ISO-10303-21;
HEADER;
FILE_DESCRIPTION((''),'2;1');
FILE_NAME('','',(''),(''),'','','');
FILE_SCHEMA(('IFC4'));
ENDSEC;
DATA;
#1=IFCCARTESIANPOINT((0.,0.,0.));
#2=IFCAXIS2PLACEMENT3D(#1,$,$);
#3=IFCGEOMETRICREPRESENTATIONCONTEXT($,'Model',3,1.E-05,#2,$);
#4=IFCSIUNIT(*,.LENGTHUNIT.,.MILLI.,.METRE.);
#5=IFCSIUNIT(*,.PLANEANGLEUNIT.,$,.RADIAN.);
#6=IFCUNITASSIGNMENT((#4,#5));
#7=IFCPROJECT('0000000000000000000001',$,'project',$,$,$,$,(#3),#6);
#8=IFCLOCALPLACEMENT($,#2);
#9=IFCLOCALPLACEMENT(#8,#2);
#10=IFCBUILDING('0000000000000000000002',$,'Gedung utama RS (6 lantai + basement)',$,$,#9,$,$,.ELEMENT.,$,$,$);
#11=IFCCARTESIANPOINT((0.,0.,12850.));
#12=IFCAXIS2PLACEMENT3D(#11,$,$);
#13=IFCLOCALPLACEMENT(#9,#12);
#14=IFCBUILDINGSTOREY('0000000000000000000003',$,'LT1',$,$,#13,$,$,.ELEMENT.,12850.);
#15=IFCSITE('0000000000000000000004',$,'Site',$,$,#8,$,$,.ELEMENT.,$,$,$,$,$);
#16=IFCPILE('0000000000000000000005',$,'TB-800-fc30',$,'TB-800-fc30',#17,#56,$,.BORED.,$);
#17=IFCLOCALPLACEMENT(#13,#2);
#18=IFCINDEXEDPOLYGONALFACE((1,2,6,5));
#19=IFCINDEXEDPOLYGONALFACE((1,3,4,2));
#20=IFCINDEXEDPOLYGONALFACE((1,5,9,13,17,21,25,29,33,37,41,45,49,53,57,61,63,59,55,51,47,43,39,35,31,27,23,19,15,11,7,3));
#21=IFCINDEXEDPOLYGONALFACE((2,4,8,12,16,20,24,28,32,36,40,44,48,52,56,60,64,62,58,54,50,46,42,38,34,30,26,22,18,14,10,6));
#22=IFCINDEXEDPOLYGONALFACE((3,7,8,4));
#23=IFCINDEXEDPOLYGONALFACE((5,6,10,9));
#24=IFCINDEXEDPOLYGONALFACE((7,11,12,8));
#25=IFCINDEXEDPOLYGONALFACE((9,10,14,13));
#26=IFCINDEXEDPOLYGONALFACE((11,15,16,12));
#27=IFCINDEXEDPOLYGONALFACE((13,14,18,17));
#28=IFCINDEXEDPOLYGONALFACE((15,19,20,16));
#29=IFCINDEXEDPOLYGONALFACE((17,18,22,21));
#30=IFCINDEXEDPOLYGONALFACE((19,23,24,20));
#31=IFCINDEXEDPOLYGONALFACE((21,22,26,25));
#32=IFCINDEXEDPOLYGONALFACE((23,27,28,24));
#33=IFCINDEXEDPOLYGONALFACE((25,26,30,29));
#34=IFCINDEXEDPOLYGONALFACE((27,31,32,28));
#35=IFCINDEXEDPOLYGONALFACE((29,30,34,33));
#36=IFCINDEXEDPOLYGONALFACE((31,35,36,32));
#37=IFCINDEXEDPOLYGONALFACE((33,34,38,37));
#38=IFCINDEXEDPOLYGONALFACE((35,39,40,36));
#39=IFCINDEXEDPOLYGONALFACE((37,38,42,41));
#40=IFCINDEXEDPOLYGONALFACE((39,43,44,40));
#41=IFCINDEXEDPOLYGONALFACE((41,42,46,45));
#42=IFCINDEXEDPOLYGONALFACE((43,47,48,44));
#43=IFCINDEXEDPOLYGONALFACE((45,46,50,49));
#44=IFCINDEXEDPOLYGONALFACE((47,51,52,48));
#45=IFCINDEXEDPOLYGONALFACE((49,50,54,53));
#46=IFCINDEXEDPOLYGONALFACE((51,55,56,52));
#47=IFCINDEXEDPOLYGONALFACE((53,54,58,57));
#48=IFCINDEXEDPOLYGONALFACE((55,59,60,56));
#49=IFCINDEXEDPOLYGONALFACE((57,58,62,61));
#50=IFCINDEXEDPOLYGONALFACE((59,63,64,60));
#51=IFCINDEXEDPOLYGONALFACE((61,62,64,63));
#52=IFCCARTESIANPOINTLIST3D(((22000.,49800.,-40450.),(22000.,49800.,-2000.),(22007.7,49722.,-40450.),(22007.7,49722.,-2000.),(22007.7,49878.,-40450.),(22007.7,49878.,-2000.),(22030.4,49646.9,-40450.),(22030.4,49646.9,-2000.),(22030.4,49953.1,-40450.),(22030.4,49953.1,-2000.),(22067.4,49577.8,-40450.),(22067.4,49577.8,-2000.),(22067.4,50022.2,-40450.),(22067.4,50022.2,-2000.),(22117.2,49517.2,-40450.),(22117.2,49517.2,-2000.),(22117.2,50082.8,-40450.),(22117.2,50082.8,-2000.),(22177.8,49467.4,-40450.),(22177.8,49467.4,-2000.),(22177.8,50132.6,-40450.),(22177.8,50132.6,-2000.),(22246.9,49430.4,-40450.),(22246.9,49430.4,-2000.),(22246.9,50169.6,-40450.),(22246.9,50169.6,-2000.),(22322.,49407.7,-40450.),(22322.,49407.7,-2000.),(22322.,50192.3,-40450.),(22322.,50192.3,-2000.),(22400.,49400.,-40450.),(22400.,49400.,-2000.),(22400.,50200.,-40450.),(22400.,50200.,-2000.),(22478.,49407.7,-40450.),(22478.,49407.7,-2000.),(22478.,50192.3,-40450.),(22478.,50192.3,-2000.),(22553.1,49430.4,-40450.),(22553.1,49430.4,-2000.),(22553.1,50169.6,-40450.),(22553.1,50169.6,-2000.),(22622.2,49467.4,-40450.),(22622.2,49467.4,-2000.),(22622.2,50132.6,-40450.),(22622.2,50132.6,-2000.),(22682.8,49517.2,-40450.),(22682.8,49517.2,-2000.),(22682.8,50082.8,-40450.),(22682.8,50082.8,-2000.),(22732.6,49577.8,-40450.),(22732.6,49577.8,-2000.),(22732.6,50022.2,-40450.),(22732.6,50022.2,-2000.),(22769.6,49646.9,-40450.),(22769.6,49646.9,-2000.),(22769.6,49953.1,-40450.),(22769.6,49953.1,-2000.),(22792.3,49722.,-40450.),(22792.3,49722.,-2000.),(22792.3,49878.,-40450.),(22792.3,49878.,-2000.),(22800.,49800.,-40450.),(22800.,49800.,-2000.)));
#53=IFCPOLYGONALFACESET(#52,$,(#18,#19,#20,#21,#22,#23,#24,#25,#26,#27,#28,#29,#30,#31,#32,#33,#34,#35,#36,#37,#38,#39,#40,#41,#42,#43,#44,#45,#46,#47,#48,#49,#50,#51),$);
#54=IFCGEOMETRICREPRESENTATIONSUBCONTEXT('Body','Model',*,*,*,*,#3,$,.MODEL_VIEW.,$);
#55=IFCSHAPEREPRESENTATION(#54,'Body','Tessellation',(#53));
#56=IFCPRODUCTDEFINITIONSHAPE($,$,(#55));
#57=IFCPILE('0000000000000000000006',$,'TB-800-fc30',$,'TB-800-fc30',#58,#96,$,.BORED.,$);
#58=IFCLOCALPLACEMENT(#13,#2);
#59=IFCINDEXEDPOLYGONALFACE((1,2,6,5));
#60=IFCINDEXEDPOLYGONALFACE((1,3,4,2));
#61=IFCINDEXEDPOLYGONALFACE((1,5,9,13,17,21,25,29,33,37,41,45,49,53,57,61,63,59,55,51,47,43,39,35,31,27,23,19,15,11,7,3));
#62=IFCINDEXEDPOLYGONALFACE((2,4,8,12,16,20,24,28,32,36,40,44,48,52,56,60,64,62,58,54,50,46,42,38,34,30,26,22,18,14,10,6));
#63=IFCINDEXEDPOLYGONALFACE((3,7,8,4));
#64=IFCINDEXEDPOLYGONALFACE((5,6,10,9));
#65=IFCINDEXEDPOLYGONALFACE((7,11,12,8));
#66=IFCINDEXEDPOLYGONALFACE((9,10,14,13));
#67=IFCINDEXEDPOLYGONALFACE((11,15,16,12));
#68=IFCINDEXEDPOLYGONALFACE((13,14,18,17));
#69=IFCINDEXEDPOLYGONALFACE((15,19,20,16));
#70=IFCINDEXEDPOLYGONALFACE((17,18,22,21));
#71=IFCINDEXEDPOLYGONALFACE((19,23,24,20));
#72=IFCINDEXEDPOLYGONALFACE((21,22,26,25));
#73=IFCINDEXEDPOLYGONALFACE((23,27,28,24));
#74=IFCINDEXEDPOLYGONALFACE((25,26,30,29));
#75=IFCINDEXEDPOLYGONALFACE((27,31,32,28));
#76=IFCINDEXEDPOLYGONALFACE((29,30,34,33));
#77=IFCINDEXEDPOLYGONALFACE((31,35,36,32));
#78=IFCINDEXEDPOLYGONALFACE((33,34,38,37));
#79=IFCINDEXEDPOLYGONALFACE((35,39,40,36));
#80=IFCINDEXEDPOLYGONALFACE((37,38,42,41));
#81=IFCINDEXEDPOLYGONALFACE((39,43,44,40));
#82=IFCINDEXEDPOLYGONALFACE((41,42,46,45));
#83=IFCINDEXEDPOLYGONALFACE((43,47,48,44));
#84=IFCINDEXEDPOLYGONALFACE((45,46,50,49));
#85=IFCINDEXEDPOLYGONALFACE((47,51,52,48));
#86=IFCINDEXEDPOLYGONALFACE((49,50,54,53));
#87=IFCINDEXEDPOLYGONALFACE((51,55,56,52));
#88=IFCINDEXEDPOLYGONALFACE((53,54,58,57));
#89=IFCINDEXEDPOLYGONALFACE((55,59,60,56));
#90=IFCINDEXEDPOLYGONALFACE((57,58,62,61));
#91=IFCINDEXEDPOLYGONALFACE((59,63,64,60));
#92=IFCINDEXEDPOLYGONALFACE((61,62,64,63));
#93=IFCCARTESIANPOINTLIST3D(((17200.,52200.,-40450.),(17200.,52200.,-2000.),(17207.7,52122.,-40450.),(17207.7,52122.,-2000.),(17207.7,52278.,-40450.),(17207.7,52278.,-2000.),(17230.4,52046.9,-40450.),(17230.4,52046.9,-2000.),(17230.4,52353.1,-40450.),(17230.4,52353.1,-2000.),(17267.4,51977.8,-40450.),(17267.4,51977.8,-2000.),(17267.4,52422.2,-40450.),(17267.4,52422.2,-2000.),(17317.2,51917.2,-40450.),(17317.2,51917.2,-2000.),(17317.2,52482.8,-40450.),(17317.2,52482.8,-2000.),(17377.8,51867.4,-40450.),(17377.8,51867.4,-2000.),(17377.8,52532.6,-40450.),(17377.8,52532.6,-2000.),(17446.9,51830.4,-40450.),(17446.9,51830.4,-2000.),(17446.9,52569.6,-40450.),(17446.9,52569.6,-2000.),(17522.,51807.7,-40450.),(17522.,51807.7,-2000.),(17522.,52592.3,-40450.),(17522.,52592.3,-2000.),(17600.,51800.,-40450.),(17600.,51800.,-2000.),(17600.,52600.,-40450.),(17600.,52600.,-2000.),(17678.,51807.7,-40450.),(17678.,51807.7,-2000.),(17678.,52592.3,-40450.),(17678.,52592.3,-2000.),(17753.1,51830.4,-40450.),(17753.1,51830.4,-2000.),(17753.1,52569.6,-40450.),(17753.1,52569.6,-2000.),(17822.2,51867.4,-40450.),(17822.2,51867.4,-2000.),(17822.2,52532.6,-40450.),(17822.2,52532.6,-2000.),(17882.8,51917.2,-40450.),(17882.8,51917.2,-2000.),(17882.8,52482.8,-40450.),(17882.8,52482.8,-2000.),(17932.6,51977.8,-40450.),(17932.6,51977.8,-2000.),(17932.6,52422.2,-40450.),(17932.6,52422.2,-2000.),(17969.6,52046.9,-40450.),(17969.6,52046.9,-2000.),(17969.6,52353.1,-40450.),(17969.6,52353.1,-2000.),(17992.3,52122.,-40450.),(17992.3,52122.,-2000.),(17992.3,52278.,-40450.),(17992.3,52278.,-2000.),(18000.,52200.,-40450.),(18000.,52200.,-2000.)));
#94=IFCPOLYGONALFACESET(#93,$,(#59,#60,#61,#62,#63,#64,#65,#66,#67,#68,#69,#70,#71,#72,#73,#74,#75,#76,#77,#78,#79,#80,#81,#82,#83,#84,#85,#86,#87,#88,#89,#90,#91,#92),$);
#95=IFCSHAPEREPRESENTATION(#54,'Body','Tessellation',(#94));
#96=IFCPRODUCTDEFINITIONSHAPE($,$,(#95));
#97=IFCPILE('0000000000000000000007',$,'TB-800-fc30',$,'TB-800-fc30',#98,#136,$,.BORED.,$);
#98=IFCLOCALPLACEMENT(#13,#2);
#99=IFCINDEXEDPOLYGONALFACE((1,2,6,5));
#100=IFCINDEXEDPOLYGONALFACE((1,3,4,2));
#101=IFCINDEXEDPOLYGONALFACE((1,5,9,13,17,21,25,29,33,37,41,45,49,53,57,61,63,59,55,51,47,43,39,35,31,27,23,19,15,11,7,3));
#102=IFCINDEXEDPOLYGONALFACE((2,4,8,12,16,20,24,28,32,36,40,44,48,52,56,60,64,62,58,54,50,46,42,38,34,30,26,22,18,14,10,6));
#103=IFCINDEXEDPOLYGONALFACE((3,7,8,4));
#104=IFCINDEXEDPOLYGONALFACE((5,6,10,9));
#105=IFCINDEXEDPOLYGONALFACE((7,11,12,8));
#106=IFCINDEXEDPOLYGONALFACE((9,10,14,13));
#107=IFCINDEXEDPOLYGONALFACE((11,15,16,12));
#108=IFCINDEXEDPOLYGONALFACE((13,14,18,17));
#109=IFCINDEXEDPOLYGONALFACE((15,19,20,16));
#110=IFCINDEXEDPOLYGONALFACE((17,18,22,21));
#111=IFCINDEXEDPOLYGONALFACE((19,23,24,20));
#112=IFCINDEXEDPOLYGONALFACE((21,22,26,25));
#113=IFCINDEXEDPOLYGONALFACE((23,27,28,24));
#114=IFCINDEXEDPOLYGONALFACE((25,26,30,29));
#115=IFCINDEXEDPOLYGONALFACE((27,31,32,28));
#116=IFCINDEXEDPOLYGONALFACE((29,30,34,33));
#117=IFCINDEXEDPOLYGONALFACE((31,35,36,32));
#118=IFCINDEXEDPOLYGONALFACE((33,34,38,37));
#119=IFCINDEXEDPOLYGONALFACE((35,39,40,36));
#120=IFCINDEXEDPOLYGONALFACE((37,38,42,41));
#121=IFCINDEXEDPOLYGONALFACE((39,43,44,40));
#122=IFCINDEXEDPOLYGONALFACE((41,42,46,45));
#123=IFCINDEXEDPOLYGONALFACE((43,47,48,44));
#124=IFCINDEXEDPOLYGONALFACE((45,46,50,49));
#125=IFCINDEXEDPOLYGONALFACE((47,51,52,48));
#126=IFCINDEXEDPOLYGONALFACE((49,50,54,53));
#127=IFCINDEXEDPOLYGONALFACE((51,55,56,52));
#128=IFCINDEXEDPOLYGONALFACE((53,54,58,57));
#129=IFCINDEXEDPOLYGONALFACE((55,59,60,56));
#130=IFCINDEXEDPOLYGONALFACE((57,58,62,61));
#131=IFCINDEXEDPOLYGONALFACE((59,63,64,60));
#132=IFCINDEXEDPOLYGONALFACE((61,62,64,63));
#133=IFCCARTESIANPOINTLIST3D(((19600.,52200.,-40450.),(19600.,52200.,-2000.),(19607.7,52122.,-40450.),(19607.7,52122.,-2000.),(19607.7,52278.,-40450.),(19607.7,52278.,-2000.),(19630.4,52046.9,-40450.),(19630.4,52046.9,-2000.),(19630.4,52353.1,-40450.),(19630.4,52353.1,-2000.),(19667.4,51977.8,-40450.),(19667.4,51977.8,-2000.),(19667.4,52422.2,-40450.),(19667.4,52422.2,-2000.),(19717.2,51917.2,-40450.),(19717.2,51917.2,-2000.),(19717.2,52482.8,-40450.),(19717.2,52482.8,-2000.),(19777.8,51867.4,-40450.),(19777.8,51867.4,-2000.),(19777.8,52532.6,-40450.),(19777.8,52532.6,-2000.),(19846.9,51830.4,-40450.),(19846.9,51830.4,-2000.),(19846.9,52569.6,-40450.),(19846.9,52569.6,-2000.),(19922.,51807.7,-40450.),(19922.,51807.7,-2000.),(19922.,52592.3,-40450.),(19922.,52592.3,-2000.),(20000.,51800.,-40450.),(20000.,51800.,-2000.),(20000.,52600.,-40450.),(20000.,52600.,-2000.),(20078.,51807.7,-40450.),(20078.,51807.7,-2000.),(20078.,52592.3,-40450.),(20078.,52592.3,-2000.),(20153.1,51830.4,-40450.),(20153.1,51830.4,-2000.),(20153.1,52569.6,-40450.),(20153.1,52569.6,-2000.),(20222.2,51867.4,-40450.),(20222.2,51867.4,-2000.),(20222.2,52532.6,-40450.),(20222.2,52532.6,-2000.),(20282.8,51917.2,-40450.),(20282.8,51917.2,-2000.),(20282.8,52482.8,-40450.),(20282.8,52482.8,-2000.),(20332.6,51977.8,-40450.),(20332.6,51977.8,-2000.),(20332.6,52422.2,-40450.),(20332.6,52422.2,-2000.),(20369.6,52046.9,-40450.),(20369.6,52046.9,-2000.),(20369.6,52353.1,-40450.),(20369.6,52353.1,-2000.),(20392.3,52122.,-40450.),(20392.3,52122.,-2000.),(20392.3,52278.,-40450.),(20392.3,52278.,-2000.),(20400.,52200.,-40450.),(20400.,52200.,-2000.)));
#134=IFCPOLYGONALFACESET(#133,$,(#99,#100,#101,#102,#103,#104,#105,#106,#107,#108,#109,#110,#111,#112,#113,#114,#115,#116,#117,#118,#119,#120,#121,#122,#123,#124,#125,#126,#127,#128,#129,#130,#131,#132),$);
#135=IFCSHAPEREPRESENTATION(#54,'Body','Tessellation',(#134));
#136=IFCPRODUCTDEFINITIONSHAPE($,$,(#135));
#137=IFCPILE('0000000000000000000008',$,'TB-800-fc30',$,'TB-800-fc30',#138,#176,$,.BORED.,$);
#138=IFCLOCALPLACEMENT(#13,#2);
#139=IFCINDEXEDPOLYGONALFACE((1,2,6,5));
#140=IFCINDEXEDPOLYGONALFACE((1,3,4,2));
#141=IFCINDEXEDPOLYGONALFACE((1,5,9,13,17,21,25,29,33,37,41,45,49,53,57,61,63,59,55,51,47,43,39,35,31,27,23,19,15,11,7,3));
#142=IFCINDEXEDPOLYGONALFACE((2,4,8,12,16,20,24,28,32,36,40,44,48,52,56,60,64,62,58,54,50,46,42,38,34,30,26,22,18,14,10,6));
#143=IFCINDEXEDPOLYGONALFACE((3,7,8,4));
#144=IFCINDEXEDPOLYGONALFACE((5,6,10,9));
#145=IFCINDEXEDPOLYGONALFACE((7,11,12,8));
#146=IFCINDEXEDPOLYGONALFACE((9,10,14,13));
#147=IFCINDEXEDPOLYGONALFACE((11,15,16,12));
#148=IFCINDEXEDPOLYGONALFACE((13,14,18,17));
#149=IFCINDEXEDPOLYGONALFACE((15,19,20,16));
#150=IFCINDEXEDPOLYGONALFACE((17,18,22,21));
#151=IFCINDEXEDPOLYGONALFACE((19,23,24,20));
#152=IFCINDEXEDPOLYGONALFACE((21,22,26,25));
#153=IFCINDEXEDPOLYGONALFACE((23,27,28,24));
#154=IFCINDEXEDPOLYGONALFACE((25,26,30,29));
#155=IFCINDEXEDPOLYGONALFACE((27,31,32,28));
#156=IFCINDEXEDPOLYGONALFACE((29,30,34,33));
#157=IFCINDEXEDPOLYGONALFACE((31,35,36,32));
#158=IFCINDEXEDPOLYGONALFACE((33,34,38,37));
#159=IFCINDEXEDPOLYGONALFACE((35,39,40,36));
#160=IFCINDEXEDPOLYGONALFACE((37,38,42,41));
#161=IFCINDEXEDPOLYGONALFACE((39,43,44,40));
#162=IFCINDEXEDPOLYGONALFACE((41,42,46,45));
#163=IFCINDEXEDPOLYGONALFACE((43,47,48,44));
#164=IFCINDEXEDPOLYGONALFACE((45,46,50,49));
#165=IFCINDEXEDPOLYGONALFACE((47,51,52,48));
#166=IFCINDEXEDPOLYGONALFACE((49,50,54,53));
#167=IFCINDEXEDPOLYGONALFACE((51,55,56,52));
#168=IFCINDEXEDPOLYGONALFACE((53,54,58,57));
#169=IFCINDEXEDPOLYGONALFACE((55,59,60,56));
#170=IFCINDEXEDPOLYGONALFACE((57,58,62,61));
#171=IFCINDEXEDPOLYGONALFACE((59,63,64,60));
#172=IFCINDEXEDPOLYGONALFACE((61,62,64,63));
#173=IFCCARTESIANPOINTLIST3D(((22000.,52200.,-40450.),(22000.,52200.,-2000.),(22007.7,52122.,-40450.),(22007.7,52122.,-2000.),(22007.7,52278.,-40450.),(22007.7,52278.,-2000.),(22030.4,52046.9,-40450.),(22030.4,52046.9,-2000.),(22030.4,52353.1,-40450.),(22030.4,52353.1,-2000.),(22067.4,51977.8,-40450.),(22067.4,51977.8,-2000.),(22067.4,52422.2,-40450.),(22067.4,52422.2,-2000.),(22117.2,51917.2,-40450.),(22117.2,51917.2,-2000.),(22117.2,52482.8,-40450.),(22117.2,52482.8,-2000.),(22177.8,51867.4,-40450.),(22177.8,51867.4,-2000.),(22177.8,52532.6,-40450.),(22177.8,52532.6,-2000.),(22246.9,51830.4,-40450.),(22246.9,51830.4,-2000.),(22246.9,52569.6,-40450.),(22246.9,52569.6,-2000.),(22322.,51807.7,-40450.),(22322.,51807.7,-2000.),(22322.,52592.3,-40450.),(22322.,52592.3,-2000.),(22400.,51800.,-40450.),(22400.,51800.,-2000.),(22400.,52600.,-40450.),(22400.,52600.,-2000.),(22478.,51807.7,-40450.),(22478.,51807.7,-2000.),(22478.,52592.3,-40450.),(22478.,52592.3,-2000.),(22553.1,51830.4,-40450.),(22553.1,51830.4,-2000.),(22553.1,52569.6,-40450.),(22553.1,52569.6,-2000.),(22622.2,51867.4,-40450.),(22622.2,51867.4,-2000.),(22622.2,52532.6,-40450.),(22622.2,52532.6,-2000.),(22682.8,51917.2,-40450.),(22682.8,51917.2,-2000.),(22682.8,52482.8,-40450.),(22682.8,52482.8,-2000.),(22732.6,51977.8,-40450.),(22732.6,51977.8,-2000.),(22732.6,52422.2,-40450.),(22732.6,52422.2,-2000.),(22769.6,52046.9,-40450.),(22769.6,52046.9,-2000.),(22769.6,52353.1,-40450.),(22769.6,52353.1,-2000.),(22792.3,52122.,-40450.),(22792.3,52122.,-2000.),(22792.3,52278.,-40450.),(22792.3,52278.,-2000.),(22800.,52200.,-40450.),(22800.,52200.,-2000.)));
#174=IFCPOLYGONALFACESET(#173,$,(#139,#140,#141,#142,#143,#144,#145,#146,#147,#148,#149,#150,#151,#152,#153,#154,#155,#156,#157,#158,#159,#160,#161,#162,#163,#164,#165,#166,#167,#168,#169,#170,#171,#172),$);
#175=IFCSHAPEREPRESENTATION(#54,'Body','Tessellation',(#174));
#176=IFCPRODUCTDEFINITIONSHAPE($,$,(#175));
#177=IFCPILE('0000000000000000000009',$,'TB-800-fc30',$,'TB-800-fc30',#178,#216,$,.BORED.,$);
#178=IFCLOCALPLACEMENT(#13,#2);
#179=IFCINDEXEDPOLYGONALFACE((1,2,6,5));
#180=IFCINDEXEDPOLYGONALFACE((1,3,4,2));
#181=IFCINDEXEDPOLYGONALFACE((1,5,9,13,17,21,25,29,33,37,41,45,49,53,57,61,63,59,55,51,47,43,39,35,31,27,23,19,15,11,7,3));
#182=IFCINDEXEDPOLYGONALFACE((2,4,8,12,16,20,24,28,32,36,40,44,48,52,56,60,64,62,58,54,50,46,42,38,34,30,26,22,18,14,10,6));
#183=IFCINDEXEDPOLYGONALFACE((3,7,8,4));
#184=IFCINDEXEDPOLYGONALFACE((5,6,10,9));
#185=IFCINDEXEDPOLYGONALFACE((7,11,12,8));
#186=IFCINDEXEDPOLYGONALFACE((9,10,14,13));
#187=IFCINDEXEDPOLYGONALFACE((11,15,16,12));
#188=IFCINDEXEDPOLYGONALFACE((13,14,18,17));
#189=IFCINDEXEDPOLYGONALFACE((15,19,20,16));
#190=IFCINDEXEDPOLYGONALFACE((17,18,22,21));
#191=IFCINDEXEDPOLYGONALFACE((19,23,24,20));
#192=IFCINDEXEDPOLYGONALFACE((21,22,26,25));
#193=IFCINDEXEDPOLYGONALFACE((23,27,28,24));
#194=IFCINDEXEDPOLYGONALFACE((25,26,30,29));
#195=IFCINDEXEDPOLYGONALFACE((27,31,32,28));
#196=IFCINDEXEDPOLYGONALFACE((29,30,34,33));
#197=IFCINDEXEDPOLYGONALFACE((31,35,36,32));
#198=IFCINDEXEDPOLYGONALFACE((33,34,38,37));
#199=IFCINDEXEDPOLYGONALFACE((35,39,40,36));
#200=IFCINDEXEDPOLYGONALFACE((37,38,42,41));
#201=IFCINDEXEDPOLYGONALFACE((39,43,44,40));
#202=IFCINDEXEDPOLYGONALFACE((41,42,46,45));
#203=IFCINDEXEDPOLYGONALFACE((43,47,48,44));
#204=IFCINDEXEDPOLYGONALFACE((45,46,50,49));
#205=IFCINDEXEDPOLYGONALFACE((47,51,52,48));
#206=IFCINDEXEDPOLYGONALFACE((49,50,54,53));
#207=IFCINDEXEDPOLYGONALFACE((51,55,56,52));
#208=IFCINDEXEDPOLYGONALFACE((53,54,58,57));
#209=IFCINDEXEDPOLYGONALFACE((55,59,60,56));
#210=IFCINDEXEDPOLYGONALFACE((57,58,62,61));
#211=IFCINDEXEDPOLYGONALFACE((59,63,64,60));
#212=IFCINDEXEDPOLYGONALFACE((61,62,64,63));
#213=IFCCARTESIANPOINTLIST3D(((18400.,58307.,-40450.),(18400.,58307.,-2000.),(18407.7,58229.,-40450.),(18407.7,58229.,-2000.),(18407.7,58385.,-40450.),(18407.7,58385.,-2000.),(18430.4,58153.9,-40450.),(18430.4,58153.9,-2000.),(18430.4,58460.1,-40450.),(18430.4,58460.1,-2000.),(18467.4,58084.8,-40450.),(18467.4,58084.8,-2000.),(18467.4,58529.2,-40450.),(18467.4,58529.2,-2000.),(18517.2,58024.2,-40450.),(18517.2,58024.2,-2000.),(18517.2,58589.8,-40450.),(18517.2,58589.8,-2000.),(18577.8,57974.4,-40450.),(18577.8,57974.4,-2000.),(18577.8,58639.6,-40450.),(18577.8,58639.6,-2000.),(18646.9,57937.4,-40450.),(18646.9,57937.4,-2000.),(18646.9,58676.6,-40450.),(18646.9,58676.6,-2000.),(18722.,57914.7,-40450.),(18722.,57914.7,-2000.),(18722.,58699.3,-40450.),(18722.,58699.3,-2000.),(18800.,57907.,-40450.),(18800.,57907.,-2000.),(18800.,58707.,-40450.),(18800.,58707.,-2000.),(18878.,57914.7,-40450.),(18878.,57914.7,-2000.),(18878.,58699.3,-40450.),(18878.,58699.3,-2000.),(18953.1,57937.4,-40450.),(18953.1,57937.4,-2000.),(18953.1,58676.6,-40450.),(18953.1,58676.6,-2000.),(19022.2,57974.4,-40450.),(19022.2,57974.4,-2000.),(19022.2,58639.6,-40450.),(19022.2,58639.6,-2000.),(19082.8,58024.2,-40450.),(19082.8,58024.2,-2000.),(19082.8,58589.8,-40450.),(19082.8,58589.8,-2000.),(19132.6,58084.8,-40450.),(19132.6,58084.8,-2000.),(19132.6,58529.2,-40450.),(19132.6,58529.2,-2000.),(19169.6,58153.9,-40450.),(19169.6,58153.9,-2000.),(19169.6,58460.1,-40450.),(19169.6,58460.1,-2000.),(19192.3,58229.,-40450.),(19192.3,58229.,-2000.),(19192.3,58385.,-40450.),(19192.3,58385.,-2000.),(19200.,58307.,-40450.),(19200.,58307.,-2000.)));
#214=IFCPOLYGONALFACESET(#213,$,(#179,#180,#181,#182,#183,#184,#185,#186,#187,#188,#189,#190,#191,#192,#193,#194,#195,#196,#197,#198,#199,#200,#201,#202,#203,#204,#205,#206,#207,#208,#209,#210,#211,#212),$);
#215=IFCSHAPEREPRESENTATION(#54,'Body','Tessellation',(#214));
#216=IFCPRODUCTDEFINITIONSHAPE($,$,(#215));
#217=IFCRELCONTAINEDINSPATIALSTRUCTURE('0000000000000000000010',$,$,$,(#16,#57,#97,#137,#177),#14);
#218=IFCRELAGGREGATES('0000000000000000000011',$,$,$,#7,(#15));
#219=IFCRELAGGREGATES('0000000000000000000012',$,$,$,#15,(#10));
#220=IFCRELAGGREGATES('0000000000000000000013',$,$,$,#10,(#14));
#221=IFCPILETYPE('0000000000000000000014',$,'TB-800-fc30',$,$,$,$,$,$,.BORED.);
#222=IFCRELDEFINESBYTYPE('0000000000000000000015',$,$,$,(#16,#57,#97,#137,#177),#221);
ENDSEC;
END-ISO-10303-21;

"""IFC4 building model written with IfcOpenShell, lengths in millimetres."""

from ifc_helpers import new_model, si_unit, frame, origin, origin_2d, place, context, subcontext, project, spatial, circle, extrude, material_profile, profile_set, profile_usage, type_object, element, save


model = new_model("IFC4")

# Units and contexts
model_context = context("Model", 3, precision=1e-05, world=origin())
body_context = subcontext(model_context, "Body", "Model", "MODEL_VIEW")
ifc_project = project(units=[si_unit("LENGTHUNIT", "METRE", prefix="MILLI"), si_unit("PLANEANGLEUNIT", "RADIAN")], contexts=[model_context])

# Site, building, storey
site_placement = place(None, origin())
site = spatial("IfcSite", under=ifc_project, at=site_placement, Name="Site", CompositionType="ELEMENT")
building_placement = place(site_placement, origin())
building = spatial("IfcBuilding", under=site, at=building_placement, Name="Gedung utama RS (6 lantai + basement)", CompositionType="ELEMENT")
storey_placement = place(building_placement, frame((0.0, 0.0, 12850.0)))
storey = spatial("IfcBuildingStorey", under=building, at=storey_placement, Name="LT1", CompositionType="ELEMENT", Elevation=12850.0)

# Piles
ifc_material_profile = material_profile(None, circle(Radius=400.0, at=origin_2d()), Name="TB-800-fc30")
ifc_profile_set = profile_set([ifc_material_profile], Name="TB-800-fc30")
ifc_profile_usage = profile_usage(ifc_profile_set, cardinal=5)
pile_type = type_object("IfcPileType", Name="TB-800-fc30", PredefinedType="BORED", material=ifc_profile_set)
for number, where, z_axis, x_axis, name in (
    (1, (22400.0, 49800.0, -40450.0), (0.0, 0.0, 1.0), (1.0, 0.0, 0.0), "TB-800-fc30"),
    (2, (17600.0, 52200.0, -40450.0), (0.0, 0.0, 1.0), (1.0, 0.0, 0.0), "TB-800-fc30"),
    (3, (20000.0, 52200.0, -40450.0), (0.0, 0.0, 1.0), (1.0, 0.0, 0.0), "TB-800-fc30"),
    (4, (22400.0, 52200.0, -40450.0), (0.0, 0.0, 1.0), (1.0, 0.0, 0.0), "TB-800-fc30"),
    (5, (18800.0, 58307.0, -40450.0), (0.0, 0.0, 1.0), (1.0, 0.0, 0.0), "TB-800-fc30"),
):
    element("IfcPile", number, at=place(storey_placement, frame(where, z_axis=z_axis, x_axis=x_axis)), inside=storey, type_object=pile_type, material=ifc_profile_usage, Name=name, ObjectType="TB-800-fc30", PredefinedType="BORED", context=body_context, shape_type="SweptSolid", body=[
        extrude(circle(Radius=400.0, at=origin_2d()), origin(), (0.0, 0.0, 1.0), 38450.0),
    ])

save(model, "model.ifc")
